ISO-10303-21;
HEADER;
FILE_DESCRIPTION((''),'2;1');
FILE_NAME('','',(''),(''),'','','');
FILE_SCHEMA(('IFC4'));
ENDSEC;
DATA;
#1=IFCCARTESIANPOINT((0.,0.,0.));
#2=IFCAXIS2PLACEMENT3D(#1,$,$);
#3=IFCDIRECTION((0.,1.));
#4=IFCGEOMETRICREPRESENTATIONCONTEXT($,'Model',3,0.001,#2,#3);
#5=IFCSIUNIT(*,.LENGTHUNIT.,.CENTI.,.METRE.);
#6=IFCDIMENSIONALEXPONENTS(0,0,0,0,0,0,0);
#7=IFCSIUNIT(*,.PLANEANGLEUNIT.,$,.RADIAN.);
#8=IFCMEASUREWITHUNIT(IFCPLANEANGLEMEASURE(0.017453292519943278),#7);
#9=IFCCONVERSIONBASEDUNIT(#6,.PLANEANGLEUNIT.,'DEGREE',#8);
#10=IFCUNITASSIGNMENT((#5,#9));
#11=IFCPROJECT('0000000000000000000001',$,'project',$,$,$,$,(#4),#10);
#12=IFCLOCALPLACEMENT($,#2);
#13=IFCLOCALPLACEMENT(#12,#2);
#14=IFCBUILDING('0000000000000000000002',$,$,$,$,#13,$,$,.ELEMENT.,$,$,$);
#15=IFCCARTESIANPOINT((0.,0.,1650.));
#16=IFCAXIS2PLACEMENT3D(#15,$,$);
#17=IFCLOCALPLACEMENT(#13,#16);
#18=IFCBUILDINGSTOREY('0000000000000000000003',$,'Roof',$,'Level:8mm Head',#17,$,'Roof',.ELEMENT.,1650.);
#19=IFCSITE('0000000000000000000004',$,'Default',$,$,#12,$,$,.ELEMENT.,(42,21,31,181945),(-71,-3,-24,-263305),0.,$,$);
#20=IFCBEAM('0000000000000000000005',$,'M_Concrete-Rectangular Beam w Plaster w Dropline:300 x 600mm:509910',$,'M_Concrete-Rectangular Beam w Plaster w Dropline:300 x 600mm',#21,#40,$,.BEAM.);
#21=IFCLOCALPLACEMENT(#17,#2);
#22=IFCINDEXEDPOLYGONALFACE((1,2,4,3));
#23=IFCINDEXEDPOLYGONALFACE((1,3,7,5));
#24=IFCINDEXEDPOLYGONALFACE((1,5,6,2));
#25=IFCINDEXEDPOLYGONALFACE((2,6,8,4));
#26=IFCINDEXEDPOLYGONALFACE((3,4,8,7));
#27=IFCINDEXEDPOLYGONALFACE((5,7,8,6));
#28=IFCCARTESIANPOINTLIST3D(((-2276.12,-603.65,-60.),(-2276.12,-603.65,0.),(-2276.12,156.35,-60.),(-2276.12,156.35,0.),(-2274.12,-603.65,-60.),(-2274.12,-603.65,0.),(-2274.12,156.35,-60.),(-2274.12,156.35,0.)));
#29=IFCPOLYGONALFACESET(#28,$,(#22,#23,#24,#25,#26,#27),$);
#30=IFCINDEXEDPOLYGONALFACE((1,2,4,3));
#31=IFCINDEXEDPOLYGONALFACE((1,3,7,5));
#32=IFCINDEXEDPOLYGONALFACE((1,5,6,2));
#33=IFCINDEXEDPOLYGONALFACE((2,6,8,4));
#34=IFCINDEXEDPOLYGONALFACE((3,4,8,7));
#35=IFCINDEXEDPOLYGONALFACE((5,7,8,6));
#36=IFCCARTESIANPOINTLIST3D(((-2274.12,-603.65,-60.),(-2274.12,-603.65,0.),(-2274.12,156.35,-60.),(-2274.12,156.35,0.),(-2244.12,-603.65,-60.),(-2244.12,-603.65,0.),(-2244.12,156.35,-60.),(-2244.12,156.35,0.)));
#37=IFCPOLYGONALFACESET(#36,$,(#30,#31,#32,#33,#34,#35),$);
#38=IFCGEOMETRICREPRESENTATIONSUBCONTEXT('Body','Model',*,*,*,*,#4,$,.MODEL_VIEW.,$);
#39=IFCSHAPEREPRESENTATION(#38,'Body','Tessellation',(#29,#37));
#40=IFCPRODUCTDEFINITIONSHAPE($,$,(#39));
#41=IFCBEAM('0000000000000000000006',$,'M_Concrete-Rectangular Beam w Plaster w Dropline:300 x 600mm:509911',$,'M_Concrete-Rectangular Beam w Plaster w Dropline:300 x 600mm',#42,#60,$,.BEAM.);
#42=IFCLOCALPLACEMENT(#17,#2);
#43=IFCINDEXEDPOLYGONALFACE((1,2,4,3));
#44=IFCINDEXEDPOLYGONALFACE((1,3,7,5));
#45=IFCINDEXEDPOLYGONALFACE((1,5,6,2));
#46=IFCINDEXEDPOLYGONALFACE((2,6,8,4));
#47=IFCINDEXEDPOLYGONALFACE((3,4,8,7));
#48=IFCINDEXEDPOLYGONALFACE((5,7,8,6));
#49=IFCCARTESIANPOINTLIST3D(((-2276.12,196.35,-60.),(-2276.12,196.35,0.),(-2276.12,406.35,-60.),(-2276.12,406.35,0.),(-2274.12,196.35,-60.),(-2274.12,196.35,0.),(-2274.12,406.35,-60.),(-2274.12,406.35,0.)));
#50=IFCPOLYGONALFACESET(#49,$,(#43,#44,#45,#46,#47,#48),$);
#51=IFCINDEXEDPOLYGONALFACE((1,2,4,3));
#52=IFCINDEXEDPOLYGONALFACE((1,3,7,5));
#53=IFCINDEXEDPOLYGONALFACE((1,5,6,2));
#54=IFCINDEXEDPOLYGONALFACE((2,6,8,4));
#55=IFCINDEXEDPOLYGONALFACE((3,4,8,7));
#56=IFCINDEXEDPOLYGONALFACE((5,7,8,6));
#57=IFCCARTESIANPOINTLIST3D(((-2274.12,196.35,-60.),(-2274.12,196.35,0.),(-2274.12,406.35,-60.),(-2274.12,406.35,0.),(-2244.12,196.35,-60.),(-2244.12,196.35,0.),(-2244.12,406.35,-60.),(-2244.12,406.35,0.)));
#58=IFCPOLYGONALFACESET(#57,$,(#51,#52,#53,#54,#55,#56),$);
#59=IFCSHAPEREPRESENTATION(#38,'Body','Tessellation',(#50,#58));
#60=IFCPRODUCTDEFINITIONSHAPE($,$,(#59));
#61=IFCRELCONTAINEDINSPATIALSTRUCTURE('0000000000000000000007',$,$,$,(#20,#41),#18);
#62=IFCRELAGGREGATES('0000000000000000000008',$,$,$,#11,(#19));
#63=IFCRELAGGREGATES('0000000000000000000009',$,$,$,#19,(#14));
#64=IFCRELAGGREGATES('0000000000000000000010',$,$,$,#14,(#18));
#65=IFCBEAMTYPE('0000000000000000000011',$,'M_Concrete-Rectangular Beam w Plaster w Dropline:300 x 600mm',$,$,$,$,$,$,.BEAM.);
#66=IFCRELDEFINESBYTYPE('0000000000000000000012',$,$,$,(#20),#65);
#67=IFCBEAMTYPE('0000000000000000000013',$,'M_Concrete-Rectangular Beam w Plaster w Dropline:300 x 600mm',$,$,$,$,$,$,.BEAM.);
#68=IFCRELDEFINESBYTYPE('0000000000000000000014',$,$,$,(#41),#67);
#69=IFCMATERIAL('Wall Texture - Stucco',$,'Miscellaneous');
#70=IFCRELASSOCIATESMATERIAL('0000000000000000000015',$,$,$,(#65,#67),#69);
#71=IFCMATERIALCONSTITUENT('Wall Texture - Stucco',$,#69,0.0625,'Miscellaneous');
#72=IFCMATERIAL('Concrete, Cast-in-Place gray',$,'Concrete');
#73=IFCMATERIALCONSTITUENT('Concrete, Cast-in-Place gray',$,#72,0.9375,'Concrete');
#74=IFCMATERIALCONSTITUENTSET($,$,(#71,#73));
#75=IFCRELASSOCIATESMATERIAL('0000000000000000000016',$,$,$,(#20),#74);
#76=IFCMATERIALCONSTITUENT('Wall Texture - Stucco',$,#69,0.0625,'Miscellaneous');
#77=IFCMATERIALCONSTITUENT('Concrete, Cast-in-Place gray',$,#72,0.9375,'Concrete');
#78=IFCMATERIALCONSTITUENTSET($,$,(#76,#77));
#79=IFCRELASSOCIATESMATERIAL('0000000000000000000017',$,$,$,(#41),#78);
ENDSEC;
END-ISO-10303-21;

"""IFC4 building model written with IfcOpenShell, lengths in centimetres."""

from ifc_helpers import new_model, entity, si_unit, converted_unit, direction, frame, origin, place, context, subcontext, project, spatial, indexed_curve, outline, extrude, source, transform, mapped, material, constituent, constituent_set, type_object, type_shapes, element, save


model = new_model("IFC4")

# Units and contexts
model_context = context("Model", 3, precision=0.001, world=origin(), true_north=direction((0.0, 1.0)))
body_context = subcontext(model_context, "Body", "Model", "MODEL_VIEW")
ifc_project = project(units=[si_unit("LENGTHUNIT", "METRE", prefix="CENTI"), converted_unit("PLANEANGLEUNIT", "DEGREE", entity("IfcPlaneAngleMeasure", 0.017453292519943278), si_unit("PLANEANGLEUNIT", "RADIAN"), dimensions=[0, 0, 0, 0, 0, 0, 0])], contexts=[model_context])

# Site, building, storey
site_placement = place(None, origin())
site = spatial("IfcSite", under=ifc_project, at=site_placement, Name="Default", CompositionType="ELEMENT", RefLatitude=(42, 21, 31, 181945), RefLongitude=(-71, -3, -24, -263305), RefElevation=0.0)
building_placement = place(site_placement, origin())
building = spatial("IfcBuilding", under=site, at=building_placement, CompositionType="ELEMENT")
storey_placement = place(building_placement, frame((0.0, 0.0, 1650.0)))
storey = spatial("IfcBuildingStorey", under=building, at=storey_placement, Name="Roof", ObjectType="Level:8mm Head", LongName="Roof", CompositionType="ELEMENT", Elevation=1650.0)

# Beams
ifc_material_1 = material(Name="Concrete, Cast-in-Place gray", Category="Concrete")
ifc_material_2 = material(Name="Wall Texture - Stucco", Category="Miscellaneous")
ifc_constituent_1 = constituent(ifc_material_2, Name="Wall Texture - Stucco", Category="Miscellaneous", fraction=0.0625)
ifc_constituent_2 = constituent(ifc_material_1, Name="Concrete, Cast-in-Place gray", Category="Concrete", fraction=0.9375)
ifc_constituent_set_1 = constituent_set(constituents=[ifc_constituent_1, ifc_constituent_2])
beam_type_1 = type_object("IfcBeamType", Name="M_Concrete-Rectangular Beam w Plaster w Dropline:300 x 600mm", PredefinedType="BEAM", material=ifc_material_2)
shared_shape_1 = source(origin(), body_context, "Body", "SweptSolid", [
    extrude(outline(indexed_curve([(-1.0, -30.0), (1.0, -30.0), (1.0, 30.0), (-1.0, 30.0), (-1.0, -30.0)], self_intersect=False)), frame((-2275.12, -603.65, 1620.0), z_axis=(0.0, 1.0, 0.0), x_axis=(-1.0, 0.0, 0.0)), (0.0, 0.0, 1.0), 760.0),
    extrude(outline(indexed_curve([(-15.0, -30.0), (15.0, -30.0), (15.0, 30.0), (-15.0, 30.0), (-15.0, -30.0)], self_intersect=False)), frame((-2259.12, -603.65, 1620.0), z_axis=(0.0, 1.0, 0.0), x_axis=(-1.0, 0.0, 0.0)), (0.0, 0.0, 1.0), 760.0),
])
type_shapes(beam_type_1, [shared_shape_1])
beam_1_placement = place(storey_placement, frame((0.0, 0.0, -1650.0)))
element("IfcBeam", 1, at=beam_1_placement, inside=storey, type_object=beam_type_1, material=ifc_constituent_set_1, Name="M_Concrete-Rectangular Beam w Plaster w Dropline:300 x 600mm:509910", ObjectType="M_Concrete-Rectangular Beam w Plaster w Dropline:300 x 600mm", PredefinedType="BEAM", context=body_context, shape_type="MappedRepresentation", body=[
    mapped(shared_shape_1, transform((0.0, 0.0, 0.0), scale=1.0)),
])
ifc_constituent_3 = constituent(ifc_material_2, Name="Wall Texture - Stucco", Category="Miscellaneous", fraction=0.0625)
ifc_constituent_4 = constituent(ifc_material_1, Name="Concrete, Cast-in-Place gray", Category="Concrete", fraction=0.9375)
ifc_constituent_set_2 = constituent_set(constituents=[ifc_constituent_3, ifc_constituent_4])
beam_type_2 = type_object("IfcBeamType", Name="M_Concrete-Rectangular Beam w Plaster w Dropline:300 x 600mm", PredefinedType="BEAM", material=ifc_material_2)
shared_shape_2 = source(origin(), body_context, "Body", "SweptSolid", [
    extrude(outline(indexed_curve([(-1.0, -30.0), (1.0, -30.0), (1.0, 30.0), (-1.0, 30.0), (-1.0, -30.0)], self_intersect=False)), frame((-2275.12, 196.35, 1620.0), z_axis=(0.0, 1.0, 0.0), x_axis=(-1.0, 0.0, 0.0)), (0.0, 0.0, 1.0), 210.0),
    extrude(outline(indexed_curve([(-15.0, -30.0), (15.0, -30.0), (15.0, 30.0), (-15.0, 30.0), (-15.0, -30.0)], self_intersect=False)), frame((-2259.12, 196.35, 1620.0), z_axis=(0.0, 1.0, 0.0), x_axis=(-1.0, 0.0, 0.0)), (0.0, 0.0, 1.0), 210.0),
])
type_shapes(beam_type_2, [shared_shape_2])
beam_2_placement = place(storey_placement, frame((0.0, 0.0, -1650.0)))
element("IfcBeam", 2, at=beam_2_placement, inside=storey, type_object=beam_type_2, material=ifc_constituent_set_2, Name="M_Concrete-Rectangular Beam w Plaster w Dropline:300 x 600mm:509911", ObjectType="M_Concrete-Rectangular Beam w Plaster w Dropline:300 x 600mm", PredefinedType="BEAM", context=body_context, shape_type="MappedRepresentation", body=[
    mapped(shared_shape_2, transform((0.0, 0.0, 0.0), scale=1.0)),
])

save(model, "model.ifc")
